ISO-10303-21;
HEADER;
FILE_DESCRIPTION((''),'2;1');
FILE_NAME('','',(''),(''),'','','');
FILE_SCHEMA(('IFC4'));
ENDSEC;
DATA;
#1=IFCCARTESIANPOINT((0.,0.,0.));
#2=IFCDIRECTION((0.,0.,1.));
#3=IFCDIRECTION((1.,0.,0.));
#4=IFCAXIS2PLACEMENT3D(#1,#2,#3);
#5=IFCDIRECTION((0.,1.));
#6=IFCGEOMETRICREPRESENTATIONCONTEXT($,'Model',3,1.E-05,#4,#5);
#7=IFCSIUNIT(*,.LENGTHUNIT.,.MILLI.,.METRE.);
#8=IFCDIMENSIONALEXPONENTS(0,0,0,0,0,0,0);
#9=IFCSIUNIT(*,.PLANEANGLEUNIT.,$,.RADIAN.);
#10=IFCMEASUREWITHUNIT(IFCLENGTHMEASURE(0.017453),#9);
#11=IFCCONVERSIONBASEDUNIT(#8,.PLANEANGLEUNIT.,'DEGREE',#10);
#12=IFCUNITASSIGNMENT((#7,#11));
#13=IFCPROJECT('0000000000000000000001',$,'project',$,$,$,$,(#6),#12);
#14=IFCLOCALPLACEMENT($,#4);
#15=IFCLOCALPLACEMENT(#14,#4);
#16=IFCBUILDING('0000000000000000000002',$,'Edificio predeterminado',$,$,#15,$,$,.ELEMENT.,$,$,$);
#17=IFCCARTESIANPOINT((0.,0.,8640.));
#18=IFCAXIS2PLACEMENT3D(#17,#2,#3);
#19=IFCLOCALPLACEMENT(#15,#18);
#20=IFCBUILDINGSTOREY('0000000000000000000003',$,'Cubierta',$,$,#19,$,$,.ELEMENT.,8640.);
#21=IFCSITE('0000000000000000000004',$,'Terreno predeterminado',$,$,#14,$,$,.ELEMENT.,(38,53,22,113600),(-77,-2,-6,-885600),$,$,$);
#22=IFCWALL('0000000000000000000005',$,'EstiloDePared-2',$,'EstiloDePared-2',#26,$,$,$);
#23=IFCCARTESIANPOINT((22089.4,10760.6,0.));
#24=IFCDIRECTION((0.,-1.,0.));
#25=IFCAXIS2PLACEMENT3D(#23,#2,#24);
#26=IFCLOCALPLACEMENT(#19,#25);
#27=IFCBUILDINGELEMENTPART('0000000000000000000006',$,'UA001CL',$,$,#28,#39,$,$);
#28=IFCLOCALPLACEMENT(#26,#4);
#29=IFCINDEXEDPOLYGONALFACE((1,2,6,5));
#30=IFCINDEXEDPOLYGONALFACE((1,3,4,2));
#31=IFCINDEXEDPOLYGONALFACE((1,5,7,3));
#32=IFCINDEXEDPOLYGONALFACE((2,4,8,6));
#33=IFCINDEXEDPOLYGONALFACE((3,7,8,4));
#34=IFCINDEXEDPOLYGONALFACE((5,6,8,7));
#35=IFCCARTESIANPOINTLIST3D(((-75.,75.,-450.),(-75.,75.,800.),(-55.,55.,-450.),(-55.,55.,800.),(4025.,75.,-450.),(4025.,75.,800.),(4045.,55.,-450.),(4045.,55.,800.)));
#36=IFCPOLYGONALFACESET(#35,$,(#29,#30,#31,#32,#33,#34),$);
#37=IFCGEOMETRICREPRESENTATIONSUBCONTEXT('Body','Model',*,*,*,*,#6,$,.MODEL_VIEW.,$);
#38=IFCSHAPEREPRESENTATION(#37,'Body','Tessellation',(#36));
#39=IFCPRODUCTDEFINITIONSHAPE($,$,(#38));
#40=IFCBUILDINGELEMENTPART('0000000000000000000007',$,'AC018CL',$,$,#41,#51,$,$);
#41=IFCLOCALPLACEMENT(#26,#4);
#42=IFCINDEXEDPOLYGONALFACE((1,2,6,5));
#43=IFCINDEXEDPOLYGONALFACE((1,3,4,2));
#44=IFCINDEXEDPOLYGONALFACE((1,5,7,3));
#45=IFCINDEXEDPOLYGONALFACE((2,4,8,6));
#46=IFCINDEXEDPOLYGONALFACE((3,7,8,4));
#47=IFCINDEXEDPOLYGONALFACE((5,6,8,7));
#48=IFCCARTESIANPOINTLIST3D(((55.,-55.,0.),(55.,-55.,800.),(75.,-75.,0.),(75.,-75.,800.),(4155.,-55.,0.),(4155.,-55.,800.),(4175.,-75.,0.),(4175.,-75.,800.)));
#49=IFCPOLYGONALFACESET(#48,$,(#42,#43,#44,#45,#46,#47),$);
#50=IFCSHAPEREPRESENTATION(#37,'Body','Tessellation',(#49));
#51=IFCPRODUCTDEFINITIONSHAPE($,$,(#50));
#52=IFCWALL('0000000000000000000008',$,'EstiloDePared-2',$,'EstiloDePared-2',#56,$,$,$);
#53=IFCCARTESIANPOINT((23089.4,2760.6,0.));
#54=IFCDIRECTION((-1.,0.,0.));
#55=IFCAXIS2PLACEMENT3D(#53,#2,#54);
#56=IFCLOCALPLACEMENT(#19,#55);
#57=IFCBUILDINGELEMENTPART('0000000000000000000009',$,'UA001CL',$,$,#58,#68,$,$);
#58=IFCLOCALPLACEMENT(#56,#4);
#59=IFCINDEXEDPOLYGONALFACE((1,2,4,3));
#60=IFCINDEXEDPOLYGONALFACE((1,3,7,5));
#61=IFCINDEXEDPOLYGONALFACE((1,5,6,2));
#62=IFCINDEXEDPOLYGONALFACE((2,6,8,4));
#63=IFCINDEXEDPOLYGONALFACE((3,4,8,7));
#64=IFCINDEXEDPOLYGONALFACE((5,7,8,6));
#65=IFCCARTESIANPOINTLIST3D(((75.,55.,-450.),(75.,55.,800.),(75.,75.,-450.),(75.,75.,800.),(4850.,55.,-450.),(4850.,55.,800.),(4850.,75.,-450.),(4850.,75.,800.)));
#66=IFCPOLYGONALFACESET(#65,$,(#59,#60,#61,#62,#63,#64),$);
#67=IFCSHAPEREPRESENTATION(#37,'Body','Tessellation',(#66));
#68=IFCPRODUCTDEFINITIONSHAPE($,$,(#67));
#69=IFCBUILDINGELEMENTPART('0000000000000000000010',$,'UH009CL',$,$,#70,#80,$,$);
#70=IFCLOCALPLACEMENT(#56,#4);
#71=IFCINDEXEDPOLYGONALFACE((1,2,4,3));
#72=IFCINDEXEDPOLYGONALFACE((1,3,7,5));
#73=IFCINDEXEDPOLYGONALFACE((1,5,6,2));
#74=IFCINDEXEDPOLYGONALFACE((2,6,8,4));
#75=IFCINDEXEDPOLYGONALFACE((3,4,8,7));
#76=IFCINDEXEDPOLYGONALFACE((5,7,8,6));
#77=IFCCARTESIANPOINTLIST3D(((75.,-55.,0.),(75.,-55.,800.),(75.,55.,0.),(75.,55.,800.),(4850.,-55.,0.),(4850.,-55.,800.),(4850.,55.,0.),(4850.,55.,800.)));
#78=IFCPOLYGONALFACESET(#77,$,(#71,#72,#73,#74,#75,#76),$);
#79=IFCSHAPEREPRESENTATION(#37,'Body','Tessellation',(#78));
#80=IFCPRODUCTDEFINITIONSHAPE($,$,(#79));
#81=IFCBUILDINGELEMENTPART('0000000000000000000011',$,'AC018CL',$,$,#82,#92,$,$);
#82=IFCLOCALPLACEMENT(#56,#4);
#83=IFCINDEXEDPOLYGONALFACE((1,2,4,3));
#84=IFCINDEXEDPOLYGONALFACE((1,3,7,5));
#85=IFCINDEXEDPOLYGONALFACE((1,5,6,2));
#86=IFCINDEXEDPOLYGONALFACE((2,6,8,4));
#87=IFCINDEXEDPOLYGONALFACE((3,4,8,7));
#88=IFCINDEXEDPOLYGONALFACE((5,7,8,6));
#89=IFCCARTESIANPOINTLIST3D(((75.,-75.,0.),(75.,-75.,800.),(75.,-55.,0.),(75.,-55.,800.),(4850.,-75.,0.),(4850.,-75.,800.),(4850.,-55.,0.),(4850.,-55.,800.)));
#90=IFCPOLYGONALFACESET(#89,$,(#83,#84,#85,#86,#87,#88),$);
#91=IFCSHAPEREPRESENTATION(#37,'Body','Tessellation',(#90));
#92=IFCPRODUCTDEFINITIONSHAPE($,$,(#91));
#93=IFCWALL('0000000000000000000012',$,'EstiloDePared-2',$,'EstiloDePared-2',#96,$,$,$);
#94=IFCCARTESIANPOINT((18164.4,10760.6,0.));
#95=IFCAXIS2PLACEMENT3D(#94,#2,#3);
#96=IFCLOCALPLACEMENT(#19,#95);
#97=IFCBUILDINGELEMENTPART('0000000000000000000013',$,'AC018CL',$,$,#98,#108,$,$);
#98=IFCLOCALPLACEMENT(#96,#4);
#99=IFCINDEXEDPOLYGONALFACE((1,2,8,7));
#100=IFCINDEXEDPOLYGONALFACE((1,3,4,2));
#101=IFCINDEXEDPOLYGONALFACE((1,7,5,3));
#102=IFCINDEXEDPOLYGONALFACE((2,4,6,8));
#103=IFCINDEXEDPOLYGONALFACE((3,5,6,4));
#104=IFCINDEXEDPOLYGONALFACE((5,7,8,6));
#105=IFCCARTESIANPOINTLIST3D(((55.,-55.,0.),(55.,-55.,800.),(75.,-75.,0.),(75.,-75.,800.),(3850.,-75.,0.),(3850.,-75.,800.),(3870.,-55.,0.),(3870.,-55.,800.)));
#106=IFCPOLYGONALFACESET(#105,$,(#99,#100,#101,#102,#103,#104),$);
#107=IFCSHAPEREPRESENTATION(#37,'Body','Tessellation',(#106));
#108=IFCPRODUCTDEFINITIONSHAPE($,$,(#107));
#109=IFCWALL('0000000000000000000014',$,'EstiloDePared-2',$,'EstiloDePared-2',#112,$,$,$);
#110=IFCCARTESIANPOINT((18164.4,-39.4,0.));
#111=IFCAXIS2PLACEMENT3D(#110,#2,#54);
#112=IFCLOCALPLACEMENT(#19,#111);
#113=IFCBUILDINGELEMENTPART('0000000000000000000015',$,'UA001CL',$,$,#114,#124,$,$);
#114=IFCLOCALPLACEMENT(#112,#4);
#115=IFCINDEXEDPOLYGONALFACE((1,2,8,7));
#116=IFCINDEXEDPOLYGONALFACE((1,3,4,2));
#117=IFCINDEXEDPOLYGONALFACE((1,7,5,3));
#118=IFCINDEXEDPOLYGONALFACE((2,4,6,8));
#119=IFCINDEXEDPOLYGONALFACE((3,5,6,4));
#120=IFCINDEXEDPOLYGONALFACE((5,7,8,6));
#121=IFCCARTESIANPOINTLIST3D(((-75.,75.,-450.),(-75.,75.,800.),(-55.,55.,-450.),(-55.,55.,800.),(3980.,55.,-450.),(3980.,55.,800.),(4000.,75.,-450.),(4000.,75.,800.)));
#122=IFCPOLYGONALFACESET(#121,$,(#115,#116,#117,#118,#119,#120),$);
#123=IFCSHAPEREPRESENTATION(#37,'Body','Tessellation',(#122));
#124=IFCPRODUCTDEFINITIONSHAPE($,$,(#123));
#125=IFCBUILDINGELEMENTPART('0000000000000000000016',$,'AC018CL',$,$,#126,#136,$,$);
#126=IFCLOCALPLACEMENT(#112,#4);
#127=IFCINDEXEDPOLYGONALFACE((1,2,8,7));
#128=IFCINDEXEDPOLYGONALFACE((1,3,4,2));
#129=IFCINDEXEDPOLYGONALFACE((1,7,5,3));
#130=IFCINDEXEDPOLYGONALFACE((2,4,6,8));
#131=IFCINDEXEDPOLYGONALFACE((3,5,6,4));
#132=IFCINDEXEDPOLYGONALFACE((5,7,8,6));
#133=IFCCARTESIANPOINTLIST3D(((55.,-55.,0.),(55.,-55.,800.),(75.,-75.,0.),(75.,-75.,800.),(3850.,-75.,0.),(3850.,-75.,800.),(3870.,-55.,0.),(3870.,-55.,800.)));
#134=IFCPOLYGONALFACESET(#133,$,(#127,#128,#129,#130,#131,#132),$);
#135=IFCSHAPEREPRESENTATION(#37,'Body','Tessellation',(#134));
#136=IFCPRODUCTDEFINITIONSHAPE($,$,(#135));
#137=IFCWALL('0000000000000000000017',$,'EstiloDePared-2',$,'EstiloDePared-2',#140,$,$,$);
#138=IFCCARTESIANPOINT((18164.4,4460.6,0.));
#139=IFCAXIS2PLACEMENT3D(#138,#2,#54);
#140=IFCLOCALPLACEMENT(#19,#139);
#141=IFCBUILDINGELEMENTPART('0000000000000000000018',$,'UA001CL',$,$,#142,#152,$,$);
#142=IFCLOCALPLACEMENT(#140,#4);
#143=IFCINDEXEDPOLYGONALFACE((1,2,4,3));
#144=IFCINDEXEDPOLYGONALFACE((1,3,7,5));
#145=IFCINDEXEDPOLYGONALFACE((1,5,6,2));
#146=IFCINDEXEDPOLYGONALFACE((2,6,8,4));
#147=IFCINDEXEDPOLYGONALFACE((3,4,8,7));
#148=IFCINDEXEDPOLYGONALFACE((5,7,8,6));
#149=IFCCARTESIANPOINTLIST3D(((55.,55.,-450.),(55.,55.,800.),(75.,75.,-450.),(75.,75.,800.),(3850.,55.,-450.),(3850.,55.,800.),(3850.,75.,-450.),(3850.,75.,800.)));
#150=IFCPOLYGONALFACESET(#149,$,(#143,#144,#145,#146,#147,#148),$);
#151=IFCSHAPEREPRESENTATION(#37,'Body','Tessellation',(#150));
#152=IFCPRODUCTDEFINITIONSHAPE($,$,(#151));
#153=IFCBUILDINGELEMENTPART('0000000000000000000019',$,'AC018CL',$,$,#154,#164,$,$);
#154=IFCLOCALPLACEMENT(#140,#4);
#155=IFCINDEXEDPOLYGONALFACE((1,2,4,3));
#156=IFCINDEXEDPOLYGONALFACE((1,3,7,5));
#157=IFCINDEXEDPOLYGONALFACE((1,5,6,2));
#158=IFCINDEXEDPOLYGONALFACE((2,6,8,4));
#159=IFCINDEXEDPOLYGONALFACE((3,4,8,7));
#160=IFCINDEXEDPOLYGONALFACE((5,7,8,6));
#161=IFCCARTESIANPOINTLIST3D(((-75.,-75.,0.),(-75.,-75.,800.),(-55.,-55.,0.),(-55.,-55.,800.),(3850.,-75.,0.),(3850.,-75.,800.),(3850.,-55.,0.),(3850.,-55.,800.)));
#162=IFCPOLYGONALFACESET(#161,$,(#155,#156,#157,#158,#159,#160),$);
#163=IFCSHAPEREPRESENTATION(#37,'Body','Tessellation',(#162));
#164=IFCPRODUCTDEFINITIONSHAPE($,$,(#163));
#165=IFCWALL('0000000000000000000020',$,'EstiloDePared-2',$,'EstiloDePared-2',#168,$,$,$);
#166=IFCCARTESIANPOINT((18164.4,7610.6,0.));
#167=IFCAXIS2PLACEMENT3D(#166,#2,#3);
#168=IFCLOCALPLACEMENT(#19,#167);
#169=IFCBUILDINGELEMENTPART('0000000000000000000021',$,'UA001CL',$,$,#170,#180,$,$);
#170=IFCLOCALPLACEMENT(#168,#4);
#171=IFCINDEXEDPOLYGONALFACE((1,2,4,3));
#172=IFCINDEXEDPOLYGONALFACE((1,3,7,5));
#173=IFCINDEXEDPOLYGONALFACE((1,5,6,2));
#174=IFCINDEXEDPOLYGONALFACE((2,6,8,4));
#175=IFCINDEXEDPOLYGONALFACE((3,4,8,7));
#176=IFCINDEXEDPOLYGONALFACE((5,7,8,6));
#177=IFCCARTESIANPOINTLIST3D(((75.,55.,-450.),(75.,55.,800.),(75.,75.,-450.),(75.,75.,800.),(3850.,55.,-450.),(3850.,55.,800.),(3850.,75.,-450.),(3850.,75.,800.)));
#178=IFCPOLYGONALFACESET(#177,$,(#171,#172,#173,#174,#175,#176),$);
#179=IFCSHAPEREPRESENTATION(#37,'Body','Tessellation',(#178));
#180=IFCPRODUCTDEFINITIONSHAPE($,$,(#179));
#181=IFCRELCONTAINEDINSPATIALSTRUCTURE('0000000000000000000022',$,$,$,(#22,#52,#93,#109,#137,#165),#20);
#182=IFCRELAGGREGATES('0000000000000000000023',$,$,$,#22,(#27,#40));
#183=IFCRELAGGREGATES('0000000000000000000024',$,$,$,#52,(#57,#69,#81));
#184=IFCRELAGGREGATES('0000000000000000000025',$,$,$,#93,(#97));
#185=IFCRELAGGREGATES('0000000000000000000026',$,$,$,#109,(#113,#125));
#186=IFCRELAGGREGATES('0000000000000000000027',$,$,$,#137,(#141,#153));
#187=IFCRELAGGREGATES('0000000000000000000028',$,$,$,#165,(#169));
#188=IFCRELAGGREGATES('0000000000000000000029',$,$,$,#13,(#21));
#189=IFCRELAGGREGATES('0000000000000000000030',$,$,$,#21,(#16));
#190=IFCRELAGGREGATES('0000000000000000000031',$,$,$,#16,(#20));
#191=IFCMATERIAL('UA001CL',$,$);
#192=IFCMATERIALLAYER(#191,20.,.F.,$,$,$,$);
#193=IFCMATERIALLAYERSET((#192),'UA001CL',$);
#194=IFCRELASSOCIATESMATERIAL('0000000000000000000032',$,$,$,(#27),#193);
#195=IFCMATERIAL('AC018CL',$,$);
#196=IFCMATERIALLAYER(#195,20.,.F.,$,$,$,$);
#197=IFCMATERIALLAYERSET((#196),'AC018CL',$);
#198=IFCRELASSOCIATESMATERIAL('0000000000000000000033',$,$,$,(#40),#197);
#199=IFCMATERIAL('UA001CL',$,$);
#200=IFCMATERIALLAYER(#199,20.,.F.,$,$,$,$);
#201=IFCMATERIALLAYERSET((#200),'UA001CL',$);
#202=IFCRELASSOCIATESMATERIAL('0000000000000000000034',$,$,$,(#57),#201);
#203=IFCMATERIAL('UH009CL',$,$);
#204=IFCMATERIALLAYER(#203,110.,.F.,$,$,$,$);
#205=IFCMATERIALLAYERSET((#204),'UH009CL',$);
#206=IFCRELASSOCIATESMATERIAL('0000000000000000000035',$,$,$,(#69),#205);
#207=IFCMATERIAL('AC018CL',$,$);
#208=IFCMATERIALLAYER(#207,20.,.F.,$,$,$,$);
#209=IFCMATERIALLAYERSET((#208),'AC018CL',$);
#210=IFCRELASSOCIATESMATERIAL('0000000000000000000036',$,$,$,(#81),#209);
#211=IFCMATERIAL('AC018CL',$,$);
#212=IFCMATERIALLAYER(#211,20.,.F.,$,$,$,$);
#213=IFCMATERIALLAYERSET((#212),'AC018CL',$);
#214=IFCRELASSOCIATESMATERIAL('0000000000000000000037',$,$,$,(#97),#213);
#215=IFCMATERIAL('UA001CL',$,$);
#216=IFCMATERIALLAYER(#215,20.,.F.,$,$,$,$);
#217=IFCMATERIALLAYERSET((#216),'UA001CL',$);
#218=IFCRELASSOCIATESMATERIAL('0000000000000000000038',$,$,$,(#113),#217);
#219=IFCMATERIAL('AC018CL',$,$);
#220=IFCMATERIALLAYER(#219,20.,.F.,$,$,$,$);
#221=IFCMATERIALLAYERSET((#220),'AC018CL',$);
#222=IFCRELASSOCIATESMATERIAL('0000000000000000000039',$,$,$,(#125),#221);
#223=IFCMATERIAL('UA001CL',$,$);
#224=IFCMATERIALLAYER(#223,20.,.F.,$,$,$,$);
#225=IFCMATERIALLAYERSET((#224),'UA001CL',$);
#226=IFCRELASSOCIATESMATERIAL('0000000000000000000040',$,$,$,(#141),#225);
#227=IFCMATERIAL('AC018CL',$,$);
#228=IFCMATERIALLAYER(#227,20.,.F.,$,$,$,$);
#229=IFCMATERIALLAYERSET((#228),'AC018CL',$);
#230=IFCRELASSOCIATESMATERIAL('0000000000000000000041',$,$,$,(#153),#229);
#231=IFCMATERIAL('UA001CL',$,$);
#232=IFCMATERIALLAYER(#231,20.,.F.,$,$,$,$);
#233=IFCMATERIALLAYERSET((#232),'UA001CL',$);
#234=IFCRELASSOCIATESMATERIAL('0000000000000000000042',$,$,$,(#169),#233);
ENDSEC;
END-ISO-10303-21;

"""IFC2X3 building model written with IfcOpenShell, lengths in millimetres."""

from ifc_helpers import new_model, entity, si_unit, converted_unit, direction, frame, origin_with_axes, place, context, subcontext, project, spatial, polyline, outline, extrude, material, layer, layer_set, layer_usage, element, aggregate, save


model = new_model("IFC2X3")

# Units and contexts
model_context = context("Model", 3, precision=1e-05, world=origin_with_axes(), true_north=direction((0.0, 1.0)))
body_context = subcontext(model_context, "Body", "Model", "MODEL_VIEW")
ifc_project = project(units=[si_unit("LENGTHUNIT", "METRE", prefix="MILLI"), converted_unit("PLANEANGLEUNIT", "DEGREE", entity("IfcLengthMeasure", 0.017453), si_unit("PLANEANGLEUNIT", "RADIAN"), dimensions=[0, 0, 0, 0, 0, 0, 0])], contexts=[model_context])

# Site, building, storey
site_placement = place(None, origin_with_axes())
site = spatial("IfcSite", under=ifc_project, at=site_placement, Name="Terreno predeterminado", CompositionType="ELEMENT", RefLatitude=(38, 53, 22, 113600), RefLongitude=(-77, -2, -6, -885600))
building_placement = place(site_placement, origin_with_axes())
building = spatial("IfcBuilding", under=site, at=building_placement, Name="Edificio predeterminado", CompositionType="ELEMENT")
storey_placement = place(building_placement, frame((0.0, 0.0, 8640.0), z_axis=(0.0, 0.0, 1.0), x_axis=(1.0, 0.0, 0.0)))
storey = spatial("IfcBuildingStorey", under=building, at=storey_placement, Name="Cubierta", CompositionType="ELEMENT", Elevation=8640.0)

# Walls, building element parts
wall_1_placement = place(storey_placement, frame((22089.4, 10760.6, 0.0), z_axis=(0.0, 0.0, 1.0), x_axis=(0.0, -1.0, 0.0)))
wall_1 = element("IfcWall", 1, at=wall_1_placement, inside=storey, Name="EstiloDePared-2", ObjectType="EstiloDePared-2")
ifc_material_1 = material(Name="UA001CL")
ifc_layer_1 = layer(ifc_material_1, 20.0, ventilated=False)
ifc_layer_set_1 = layer_set([ifc_layer_1], Name="UA001CL")
ifc_layer_usage_1 = layer_usage(ifc_layer_set_1, "AXIS2", "NEGATIVE", -75.0)
building_element_part_1_placement = place(wall_1_placement, origin_with_axes())
building_element_part_1 = element("IfcBuildingElementPart", 2, at=building_element_part_1_placement, material=ifc_layer_usage_1, Name="UA001CL", context=body_context, shape_type="SweptSolid", body=[
    extrude(outline(polyline([(4025.0, 75.0), (4045.0, 55.0), (-55.0, 55.0), (-75.0, 75.0), (4025.0, 75.0)])), frame((0.0, 0.0, -450.0), z_axis=(0.0, 0.0, 1.0), x_axis=(1.0, 0.0, 0.0)), (0.0, 0.0, 1.0), 1250.0),
])
ifc_material_2 = material(Name="AC018CL")
ifc_layer_2 = layer(ifc_material_2, 20.0, ventilated=False)
ifc_layer_set_2 = layer_set([ifc_layer_2], Name="AC018CL")
ifc_layer_usage_2 = layer_usage(ifc_layer_set_2, "AXIS2", "NEGATIVE", 55.0)
building_element_part_2_placement = place(wall_1_placement, origin_with_axes())
building_element_part_2 = element("IfcBuildingElementPart", 3, at=building_element_part_2_placement, material=ifc_layer_usage_2, Name="AC018CL", context=body_context, shape_type="SweptSolid", body=[
    extrude(outline(polyline([(4155.0, -55.0), (4175.0, -75.0), (75.0, -75.0), (55.0, -55.0), (4155.0, -55.0)])), origin_with_axes(), (0.0, 0.0, 1.0), 800.0),
])
aggregate(wall_1, [building_element_part_1, building_element_part_2])
wall_2_placement = place(storey_placement, frame((23089.4, 2760.6, 0.0), z_axis=(0.0, 0.0, 1.0), x_axis=(-1.0, 0.0, 0.0)))
wall_2 = element("IfcWall", 4, at=wall_2_placement, inside=storey, Name="EstiloDePared-2", ObjectType="EstiloDePared-2")
ifc_material_3 = material(Name="UA001CL")
ifc_layer_3 = layer(ifc_material_3, 20.0, ventilated=False)
ifc_layer_set_3 = layer_set([ifc_layer_3], Name="UA001CL")
ifc_layer_usage_3 = layer_usage(ifc_layer_set_3, "AXIS2", "NEGATIVE", -75.0)
building_element_part_3_placement = place(wall_2_placement, origin_with_axes())
building_element_part_3 = element("IfcBuildingElementPart", 5, at=building_element_part_3_placement, material=ifc_layer_usage_3, Name="UA001CL", context=body_context, shape_type="SweptSolid", body=[
    extrude(outline(polyline([(4850.0, 75.0), (4850.0, 55.0), (75.0, 55.0), (75.0, 75.0), (4850.0, 75.0)])), frame((0.0, 0.0, -450.0), z_axis=(0.0, 0.0, 1.0), x_axis=(1.0, 0.0, 0.0)), (0.0, 0.0, 1.0), 1250.0),
])
ifc_material_4 = material(Name="UH009CL")
ifc_layer_4 = layer(ifc_material_4, 110.0, ventilated=False)
ifc_layer_set_4 = layer_set([ifc_layer_4], Name="UH009CL")
ifc_layer_usage_4 = layer_usage(ifc_layer_set_4, "AXIS2", "NEGATIVE", -55.0)
building_element_part_4_placement = place(wall_2_placement, origin_with_axes())
building_element_part_4 = element("IfcBuildingElementPart", 6, at=building_element_part_4_placement, material=ifc_layer_usage_4, Name="UH009CL", context=body_context, shape_type="SweptSolid", body=[
    extrude(outline(polyline([(4850.0, 55.0), (4850.0, -55.0), (75.0, -55.0), (75.0, 55.0), (4850.0, 55.0)])), origin_with_axes(), (0.0, 0.0, 1.0), 800.0),
])
ifc_material_5 = material(Name="AC018CL")
ifc_layer_5 = layer(ifc_material_5, 20.0, ventilated=False)
ifc_layer_set_5 = layer_set([ifc_layer_5], Name="AC018CL")
ifc_layer_usage_5 = layer_usage(ifc_layer_set_5, "AXIS2", "NEGATIVE", 55.0)
building_element_part_5_placement = place(wall_2_placement, origin_with_axes())
building_element_part_5 = element("IfcBuildingElementPart", 7, at=building_element_part_5_placement, material=ifc_layer_usage_5, Name="AC018CL", context=body_context, shape_type="SweptSolid", body=[
    extrude(outline(polyline([(4850.0, -55.0), (4850.0, -75.0), (75.0, -75.0), (75.0, -55.0), (4850.0, -55.0)])), origin_with_axes(), (0.0, 0.0, 1.0), 800.0),
])
aggregate(wall_2, [building_element_part_3, building_element_part_4, building_element_part_5])

# Wall, building element part
wall_3_placement = place(storey_placement, frame((18164.4, 10760.6, 0.0), z_axis=(0.0, 0.0, 1.0), x_axis=(1.0, 0.0, 0.0)))
wall_3 = element("IfcWall", 8, at=wall_3_placement, inside=storey, Name="EstiloDePared-2", ObjectType="EstiloDePared-2")
ifc_material_6 = material(Name="AC018CL")
ifc_layer_6 = layer(ifc_material_6, 20.0, ventilated=False)
ifc_layer_set_6 = layer_set([ifc_layer_6], Name="AC018CL")
ifc_layer_usage_6 = layer_usage(ifc_layer_set_6, "AXIS2", "NEGATIVE", 55.0)
building_element_part_6_placement = place(wall_3_placement, origin_with_axes())
building_element_part_6 = element("IfcBuildingElementPart", 9, at=building_element_part_6_placement, material=ifc_layer_usage_6, Name="AC018CL", context=body_context, shape_type="SweptSolid", body=[
    extrude(outline(polyline([(3870.0, -55.0), (3850.0, -75.0), (75.0, -75.0), (55.0, -55.0), (3870.0, -55.0)])), origin_with_axes(), (0.0, 0.0, 1.0), 800.0),
])
aggregate(wall_3, [building_element_part_6])

# Walls, building element parts
wall_4_placement = place(storey_placement, frame((18164.4, -39.4, 0.0), z_axis=(0.0, 0.0, 1.0), x_axis=(-1.0, 0.0, 0.0)))
wall_4 = element("IfcWall", 10, at=wall_4_placement, inside=storey, Name="EstiloDePared-2", ObjectType="EstiloDePared-2")
ifc_material_7 = material(Name="UA001CL")
ifc_layer_7 = layer(ifc_material_7, 20.0, ventilated=False)
ifc_layer_set_7 = layer_set([ifc_layer_7], Name="UA001CL")
ifc_layer_usage_7 = layer_usage(ifc_layer_set_7, "AXIS2", "NEGATIVE", -75.0)
building_element_part_7_placement = place(wall_4_placement, origin_with_axes())
building_element_part_7 = element("IfcBuildingElementPart", 11, at=building_element_part_7_placement, material=ifc_layer_usage_7, Name="UA001CL", context=body_context, shape_type="SweptSolid", body=[
    extrude(outline(polyline([(4000.0, 75.0), (3980.0, 55.0), (-55.0, 55.0), (-75.0, 75.0), (4000.0, 75.0)])), frame((0.0, 0.0, -450.0), z_axis=(0.0, 0.0, 1.0), x_axis=(1.0, 0.0, 0.0)), (0.0, 0.0, 1.0), 1250.0),
])
ifc_material_8 = material(Name="AC018CL")
ifc_layer_8 = layer(ifc_material_8, 20.0, ventilated=False)
ifc_layer_set_8 = layer_set([ifc_layer_8], Name="AC018CL")
ifc_layer_usage_8 = layer_usage(ifc_layer_set_8, "AXIS2", "NEGATIVE", 55.0)
building_element_part_8_placement = place(wall_4_placement, origin_with_axes())
building_element_part_8 = element("IfcBuildingElementPart", 12, at=building_element_part_8_placement, material=ifc_layer_usage_8, Name="AC018CL", context=body_context, shape_type="SweptSolid", body=[
    extrude(outline(polyline([(3870.0, -55.0), (3850.0, -75.0), (75.0, -75.0), (55.0, -55.0), (3870.0, -55.0)])), origin_with_axes(), (0.0, 0.0, 1.0), 800.0),
])
aggregate(wall_4, [building_element_part_7, building_element_part_8])
wall_5_placement = place(storey_placement, frame((18164.4, 4460.6, 0.0), z_axis=(0.0, 0.0, 1.0), x_axis=(-1.0, 0.0, 0.0)))
wall_5 = element("IfcWall", 13, at=wall_5_placement, inside=storey, Name="EstiloDePared-2", ObjectType="EstiloDePared-2")
ifc_material_9 = material(Name="UA001CL")
ifc_layer_9 = layer(ifc_material_9, 20.0, ventilated=False)
ifc_layer_set_9 = layer_set([ifc_layer_9], Name="UA001CL")
ifc_layer_usage_9 = layer_usage(ifc_layer_set_9, "AXIS2", "NEGATIVE", -75.0)
building_element_part_9_placement = place(wall_5_placement, origin_with_axes())
building_element_part_9 = element("IfcBuildingElementPart", 14, at=building_element_part_9_placement, material=ifc_layer_usage_9, Name="UA001CL", context=body_context, shape_type="SweptSolid", body=[
    extrude(outline(polyline([(3850.0, 75.0), (3850.0, 55.0), (55.0, 55.0), (75.0, 75.0), (3850.0, 75.0)])), frame((0.0, 0.0, -450.0), z_axis=(0.0, 0.0, 1.0), x_axis=(1.0, 0.0, 0.0)), (0.0, 0.0, 1.0), 1250.0),
])
ifc_material_10 = material(Name="AC018CL")
ifc_layer_10 = layer(ifc_material_10, 20.0, ventilated=False)
ifc_layer_set_10 = layer_set([ifc_layer_10], Name="AC018CL")
ifc_layer_usage_10 = layer_usage(ifc_layer_set_10, "AXIS2", "NEGATIVE", 55.0)
building_element_part_10_placement = place(wall_5_placement, origin_with_axes())
building_element_part_10 = element("IfcBuildingElementPart", 15, at=building_element_part_10_placement, material=ifc_layer_usage_10, Name="AC018CL", context=body_context, shape_type="SweptSolid", body=[
    extrude(outline(polyline([(3850.0, -55.0), (3850.0, -75.0), (-75.0, -75.0), (-55.0, -55.0), (3850.0, -55.0)])), origin_with_axes(), (0.0, 0.0, 1.0), 800.0),
])
aggregate(wall_5, [building_element_part_9, building_element_part_10])
wall_6_placement = place(storey_placement, frame((18164.4, 7610.6, 0.0), z_axis=(0.0, 0.0, 1.0), x_axis=(1.0, 0.0, 0.0)))
wall_6 = element("IfcWall", 16, at=wall_6_placement, inside=storey, Name="EstiloDePared-2", ObjectType="EstiloDePared-2")
ifc_material_11 = material(Name="UA001CL")
ifc_layer_11 = layer(ifc_material_11, 20.0, ventilated=False)
ifc_layer_set_11 = layer_set([ifc_layer_11], Name="UA001CL")
ifc_layer_usage_11 = layer_usage(ifc_layer_set_11, "AXIS2", "NEGATIVE", -75.0)
building_element_part_11_placement = place(wall_6_placement, origin_with_axes())
building_element_part_11 = element("IfcBuildingElementPart", 17, at=building_element_part_11_placement, material=ifc_layer_usage_11, Name="UA001CL", context=body_context, shape_type="SweptSolid", body=[
    extrude(outline(polyline([(3850.0, 75.0), (3850.0, 55.0), (75.0, 55.0), (75.0, 75.0), (3850.0, 75.0)])), frame((0.0, 0.0, -450.0), z_axis=(0.0, 0.0, 1.0), x_axis=(1.0, 0.0, 0.0)), (0.0, 0.0, 1.0), 1250.0),
])
aggregate(wall_6, [building_element_part_11])

save(model, "model.ifc")
